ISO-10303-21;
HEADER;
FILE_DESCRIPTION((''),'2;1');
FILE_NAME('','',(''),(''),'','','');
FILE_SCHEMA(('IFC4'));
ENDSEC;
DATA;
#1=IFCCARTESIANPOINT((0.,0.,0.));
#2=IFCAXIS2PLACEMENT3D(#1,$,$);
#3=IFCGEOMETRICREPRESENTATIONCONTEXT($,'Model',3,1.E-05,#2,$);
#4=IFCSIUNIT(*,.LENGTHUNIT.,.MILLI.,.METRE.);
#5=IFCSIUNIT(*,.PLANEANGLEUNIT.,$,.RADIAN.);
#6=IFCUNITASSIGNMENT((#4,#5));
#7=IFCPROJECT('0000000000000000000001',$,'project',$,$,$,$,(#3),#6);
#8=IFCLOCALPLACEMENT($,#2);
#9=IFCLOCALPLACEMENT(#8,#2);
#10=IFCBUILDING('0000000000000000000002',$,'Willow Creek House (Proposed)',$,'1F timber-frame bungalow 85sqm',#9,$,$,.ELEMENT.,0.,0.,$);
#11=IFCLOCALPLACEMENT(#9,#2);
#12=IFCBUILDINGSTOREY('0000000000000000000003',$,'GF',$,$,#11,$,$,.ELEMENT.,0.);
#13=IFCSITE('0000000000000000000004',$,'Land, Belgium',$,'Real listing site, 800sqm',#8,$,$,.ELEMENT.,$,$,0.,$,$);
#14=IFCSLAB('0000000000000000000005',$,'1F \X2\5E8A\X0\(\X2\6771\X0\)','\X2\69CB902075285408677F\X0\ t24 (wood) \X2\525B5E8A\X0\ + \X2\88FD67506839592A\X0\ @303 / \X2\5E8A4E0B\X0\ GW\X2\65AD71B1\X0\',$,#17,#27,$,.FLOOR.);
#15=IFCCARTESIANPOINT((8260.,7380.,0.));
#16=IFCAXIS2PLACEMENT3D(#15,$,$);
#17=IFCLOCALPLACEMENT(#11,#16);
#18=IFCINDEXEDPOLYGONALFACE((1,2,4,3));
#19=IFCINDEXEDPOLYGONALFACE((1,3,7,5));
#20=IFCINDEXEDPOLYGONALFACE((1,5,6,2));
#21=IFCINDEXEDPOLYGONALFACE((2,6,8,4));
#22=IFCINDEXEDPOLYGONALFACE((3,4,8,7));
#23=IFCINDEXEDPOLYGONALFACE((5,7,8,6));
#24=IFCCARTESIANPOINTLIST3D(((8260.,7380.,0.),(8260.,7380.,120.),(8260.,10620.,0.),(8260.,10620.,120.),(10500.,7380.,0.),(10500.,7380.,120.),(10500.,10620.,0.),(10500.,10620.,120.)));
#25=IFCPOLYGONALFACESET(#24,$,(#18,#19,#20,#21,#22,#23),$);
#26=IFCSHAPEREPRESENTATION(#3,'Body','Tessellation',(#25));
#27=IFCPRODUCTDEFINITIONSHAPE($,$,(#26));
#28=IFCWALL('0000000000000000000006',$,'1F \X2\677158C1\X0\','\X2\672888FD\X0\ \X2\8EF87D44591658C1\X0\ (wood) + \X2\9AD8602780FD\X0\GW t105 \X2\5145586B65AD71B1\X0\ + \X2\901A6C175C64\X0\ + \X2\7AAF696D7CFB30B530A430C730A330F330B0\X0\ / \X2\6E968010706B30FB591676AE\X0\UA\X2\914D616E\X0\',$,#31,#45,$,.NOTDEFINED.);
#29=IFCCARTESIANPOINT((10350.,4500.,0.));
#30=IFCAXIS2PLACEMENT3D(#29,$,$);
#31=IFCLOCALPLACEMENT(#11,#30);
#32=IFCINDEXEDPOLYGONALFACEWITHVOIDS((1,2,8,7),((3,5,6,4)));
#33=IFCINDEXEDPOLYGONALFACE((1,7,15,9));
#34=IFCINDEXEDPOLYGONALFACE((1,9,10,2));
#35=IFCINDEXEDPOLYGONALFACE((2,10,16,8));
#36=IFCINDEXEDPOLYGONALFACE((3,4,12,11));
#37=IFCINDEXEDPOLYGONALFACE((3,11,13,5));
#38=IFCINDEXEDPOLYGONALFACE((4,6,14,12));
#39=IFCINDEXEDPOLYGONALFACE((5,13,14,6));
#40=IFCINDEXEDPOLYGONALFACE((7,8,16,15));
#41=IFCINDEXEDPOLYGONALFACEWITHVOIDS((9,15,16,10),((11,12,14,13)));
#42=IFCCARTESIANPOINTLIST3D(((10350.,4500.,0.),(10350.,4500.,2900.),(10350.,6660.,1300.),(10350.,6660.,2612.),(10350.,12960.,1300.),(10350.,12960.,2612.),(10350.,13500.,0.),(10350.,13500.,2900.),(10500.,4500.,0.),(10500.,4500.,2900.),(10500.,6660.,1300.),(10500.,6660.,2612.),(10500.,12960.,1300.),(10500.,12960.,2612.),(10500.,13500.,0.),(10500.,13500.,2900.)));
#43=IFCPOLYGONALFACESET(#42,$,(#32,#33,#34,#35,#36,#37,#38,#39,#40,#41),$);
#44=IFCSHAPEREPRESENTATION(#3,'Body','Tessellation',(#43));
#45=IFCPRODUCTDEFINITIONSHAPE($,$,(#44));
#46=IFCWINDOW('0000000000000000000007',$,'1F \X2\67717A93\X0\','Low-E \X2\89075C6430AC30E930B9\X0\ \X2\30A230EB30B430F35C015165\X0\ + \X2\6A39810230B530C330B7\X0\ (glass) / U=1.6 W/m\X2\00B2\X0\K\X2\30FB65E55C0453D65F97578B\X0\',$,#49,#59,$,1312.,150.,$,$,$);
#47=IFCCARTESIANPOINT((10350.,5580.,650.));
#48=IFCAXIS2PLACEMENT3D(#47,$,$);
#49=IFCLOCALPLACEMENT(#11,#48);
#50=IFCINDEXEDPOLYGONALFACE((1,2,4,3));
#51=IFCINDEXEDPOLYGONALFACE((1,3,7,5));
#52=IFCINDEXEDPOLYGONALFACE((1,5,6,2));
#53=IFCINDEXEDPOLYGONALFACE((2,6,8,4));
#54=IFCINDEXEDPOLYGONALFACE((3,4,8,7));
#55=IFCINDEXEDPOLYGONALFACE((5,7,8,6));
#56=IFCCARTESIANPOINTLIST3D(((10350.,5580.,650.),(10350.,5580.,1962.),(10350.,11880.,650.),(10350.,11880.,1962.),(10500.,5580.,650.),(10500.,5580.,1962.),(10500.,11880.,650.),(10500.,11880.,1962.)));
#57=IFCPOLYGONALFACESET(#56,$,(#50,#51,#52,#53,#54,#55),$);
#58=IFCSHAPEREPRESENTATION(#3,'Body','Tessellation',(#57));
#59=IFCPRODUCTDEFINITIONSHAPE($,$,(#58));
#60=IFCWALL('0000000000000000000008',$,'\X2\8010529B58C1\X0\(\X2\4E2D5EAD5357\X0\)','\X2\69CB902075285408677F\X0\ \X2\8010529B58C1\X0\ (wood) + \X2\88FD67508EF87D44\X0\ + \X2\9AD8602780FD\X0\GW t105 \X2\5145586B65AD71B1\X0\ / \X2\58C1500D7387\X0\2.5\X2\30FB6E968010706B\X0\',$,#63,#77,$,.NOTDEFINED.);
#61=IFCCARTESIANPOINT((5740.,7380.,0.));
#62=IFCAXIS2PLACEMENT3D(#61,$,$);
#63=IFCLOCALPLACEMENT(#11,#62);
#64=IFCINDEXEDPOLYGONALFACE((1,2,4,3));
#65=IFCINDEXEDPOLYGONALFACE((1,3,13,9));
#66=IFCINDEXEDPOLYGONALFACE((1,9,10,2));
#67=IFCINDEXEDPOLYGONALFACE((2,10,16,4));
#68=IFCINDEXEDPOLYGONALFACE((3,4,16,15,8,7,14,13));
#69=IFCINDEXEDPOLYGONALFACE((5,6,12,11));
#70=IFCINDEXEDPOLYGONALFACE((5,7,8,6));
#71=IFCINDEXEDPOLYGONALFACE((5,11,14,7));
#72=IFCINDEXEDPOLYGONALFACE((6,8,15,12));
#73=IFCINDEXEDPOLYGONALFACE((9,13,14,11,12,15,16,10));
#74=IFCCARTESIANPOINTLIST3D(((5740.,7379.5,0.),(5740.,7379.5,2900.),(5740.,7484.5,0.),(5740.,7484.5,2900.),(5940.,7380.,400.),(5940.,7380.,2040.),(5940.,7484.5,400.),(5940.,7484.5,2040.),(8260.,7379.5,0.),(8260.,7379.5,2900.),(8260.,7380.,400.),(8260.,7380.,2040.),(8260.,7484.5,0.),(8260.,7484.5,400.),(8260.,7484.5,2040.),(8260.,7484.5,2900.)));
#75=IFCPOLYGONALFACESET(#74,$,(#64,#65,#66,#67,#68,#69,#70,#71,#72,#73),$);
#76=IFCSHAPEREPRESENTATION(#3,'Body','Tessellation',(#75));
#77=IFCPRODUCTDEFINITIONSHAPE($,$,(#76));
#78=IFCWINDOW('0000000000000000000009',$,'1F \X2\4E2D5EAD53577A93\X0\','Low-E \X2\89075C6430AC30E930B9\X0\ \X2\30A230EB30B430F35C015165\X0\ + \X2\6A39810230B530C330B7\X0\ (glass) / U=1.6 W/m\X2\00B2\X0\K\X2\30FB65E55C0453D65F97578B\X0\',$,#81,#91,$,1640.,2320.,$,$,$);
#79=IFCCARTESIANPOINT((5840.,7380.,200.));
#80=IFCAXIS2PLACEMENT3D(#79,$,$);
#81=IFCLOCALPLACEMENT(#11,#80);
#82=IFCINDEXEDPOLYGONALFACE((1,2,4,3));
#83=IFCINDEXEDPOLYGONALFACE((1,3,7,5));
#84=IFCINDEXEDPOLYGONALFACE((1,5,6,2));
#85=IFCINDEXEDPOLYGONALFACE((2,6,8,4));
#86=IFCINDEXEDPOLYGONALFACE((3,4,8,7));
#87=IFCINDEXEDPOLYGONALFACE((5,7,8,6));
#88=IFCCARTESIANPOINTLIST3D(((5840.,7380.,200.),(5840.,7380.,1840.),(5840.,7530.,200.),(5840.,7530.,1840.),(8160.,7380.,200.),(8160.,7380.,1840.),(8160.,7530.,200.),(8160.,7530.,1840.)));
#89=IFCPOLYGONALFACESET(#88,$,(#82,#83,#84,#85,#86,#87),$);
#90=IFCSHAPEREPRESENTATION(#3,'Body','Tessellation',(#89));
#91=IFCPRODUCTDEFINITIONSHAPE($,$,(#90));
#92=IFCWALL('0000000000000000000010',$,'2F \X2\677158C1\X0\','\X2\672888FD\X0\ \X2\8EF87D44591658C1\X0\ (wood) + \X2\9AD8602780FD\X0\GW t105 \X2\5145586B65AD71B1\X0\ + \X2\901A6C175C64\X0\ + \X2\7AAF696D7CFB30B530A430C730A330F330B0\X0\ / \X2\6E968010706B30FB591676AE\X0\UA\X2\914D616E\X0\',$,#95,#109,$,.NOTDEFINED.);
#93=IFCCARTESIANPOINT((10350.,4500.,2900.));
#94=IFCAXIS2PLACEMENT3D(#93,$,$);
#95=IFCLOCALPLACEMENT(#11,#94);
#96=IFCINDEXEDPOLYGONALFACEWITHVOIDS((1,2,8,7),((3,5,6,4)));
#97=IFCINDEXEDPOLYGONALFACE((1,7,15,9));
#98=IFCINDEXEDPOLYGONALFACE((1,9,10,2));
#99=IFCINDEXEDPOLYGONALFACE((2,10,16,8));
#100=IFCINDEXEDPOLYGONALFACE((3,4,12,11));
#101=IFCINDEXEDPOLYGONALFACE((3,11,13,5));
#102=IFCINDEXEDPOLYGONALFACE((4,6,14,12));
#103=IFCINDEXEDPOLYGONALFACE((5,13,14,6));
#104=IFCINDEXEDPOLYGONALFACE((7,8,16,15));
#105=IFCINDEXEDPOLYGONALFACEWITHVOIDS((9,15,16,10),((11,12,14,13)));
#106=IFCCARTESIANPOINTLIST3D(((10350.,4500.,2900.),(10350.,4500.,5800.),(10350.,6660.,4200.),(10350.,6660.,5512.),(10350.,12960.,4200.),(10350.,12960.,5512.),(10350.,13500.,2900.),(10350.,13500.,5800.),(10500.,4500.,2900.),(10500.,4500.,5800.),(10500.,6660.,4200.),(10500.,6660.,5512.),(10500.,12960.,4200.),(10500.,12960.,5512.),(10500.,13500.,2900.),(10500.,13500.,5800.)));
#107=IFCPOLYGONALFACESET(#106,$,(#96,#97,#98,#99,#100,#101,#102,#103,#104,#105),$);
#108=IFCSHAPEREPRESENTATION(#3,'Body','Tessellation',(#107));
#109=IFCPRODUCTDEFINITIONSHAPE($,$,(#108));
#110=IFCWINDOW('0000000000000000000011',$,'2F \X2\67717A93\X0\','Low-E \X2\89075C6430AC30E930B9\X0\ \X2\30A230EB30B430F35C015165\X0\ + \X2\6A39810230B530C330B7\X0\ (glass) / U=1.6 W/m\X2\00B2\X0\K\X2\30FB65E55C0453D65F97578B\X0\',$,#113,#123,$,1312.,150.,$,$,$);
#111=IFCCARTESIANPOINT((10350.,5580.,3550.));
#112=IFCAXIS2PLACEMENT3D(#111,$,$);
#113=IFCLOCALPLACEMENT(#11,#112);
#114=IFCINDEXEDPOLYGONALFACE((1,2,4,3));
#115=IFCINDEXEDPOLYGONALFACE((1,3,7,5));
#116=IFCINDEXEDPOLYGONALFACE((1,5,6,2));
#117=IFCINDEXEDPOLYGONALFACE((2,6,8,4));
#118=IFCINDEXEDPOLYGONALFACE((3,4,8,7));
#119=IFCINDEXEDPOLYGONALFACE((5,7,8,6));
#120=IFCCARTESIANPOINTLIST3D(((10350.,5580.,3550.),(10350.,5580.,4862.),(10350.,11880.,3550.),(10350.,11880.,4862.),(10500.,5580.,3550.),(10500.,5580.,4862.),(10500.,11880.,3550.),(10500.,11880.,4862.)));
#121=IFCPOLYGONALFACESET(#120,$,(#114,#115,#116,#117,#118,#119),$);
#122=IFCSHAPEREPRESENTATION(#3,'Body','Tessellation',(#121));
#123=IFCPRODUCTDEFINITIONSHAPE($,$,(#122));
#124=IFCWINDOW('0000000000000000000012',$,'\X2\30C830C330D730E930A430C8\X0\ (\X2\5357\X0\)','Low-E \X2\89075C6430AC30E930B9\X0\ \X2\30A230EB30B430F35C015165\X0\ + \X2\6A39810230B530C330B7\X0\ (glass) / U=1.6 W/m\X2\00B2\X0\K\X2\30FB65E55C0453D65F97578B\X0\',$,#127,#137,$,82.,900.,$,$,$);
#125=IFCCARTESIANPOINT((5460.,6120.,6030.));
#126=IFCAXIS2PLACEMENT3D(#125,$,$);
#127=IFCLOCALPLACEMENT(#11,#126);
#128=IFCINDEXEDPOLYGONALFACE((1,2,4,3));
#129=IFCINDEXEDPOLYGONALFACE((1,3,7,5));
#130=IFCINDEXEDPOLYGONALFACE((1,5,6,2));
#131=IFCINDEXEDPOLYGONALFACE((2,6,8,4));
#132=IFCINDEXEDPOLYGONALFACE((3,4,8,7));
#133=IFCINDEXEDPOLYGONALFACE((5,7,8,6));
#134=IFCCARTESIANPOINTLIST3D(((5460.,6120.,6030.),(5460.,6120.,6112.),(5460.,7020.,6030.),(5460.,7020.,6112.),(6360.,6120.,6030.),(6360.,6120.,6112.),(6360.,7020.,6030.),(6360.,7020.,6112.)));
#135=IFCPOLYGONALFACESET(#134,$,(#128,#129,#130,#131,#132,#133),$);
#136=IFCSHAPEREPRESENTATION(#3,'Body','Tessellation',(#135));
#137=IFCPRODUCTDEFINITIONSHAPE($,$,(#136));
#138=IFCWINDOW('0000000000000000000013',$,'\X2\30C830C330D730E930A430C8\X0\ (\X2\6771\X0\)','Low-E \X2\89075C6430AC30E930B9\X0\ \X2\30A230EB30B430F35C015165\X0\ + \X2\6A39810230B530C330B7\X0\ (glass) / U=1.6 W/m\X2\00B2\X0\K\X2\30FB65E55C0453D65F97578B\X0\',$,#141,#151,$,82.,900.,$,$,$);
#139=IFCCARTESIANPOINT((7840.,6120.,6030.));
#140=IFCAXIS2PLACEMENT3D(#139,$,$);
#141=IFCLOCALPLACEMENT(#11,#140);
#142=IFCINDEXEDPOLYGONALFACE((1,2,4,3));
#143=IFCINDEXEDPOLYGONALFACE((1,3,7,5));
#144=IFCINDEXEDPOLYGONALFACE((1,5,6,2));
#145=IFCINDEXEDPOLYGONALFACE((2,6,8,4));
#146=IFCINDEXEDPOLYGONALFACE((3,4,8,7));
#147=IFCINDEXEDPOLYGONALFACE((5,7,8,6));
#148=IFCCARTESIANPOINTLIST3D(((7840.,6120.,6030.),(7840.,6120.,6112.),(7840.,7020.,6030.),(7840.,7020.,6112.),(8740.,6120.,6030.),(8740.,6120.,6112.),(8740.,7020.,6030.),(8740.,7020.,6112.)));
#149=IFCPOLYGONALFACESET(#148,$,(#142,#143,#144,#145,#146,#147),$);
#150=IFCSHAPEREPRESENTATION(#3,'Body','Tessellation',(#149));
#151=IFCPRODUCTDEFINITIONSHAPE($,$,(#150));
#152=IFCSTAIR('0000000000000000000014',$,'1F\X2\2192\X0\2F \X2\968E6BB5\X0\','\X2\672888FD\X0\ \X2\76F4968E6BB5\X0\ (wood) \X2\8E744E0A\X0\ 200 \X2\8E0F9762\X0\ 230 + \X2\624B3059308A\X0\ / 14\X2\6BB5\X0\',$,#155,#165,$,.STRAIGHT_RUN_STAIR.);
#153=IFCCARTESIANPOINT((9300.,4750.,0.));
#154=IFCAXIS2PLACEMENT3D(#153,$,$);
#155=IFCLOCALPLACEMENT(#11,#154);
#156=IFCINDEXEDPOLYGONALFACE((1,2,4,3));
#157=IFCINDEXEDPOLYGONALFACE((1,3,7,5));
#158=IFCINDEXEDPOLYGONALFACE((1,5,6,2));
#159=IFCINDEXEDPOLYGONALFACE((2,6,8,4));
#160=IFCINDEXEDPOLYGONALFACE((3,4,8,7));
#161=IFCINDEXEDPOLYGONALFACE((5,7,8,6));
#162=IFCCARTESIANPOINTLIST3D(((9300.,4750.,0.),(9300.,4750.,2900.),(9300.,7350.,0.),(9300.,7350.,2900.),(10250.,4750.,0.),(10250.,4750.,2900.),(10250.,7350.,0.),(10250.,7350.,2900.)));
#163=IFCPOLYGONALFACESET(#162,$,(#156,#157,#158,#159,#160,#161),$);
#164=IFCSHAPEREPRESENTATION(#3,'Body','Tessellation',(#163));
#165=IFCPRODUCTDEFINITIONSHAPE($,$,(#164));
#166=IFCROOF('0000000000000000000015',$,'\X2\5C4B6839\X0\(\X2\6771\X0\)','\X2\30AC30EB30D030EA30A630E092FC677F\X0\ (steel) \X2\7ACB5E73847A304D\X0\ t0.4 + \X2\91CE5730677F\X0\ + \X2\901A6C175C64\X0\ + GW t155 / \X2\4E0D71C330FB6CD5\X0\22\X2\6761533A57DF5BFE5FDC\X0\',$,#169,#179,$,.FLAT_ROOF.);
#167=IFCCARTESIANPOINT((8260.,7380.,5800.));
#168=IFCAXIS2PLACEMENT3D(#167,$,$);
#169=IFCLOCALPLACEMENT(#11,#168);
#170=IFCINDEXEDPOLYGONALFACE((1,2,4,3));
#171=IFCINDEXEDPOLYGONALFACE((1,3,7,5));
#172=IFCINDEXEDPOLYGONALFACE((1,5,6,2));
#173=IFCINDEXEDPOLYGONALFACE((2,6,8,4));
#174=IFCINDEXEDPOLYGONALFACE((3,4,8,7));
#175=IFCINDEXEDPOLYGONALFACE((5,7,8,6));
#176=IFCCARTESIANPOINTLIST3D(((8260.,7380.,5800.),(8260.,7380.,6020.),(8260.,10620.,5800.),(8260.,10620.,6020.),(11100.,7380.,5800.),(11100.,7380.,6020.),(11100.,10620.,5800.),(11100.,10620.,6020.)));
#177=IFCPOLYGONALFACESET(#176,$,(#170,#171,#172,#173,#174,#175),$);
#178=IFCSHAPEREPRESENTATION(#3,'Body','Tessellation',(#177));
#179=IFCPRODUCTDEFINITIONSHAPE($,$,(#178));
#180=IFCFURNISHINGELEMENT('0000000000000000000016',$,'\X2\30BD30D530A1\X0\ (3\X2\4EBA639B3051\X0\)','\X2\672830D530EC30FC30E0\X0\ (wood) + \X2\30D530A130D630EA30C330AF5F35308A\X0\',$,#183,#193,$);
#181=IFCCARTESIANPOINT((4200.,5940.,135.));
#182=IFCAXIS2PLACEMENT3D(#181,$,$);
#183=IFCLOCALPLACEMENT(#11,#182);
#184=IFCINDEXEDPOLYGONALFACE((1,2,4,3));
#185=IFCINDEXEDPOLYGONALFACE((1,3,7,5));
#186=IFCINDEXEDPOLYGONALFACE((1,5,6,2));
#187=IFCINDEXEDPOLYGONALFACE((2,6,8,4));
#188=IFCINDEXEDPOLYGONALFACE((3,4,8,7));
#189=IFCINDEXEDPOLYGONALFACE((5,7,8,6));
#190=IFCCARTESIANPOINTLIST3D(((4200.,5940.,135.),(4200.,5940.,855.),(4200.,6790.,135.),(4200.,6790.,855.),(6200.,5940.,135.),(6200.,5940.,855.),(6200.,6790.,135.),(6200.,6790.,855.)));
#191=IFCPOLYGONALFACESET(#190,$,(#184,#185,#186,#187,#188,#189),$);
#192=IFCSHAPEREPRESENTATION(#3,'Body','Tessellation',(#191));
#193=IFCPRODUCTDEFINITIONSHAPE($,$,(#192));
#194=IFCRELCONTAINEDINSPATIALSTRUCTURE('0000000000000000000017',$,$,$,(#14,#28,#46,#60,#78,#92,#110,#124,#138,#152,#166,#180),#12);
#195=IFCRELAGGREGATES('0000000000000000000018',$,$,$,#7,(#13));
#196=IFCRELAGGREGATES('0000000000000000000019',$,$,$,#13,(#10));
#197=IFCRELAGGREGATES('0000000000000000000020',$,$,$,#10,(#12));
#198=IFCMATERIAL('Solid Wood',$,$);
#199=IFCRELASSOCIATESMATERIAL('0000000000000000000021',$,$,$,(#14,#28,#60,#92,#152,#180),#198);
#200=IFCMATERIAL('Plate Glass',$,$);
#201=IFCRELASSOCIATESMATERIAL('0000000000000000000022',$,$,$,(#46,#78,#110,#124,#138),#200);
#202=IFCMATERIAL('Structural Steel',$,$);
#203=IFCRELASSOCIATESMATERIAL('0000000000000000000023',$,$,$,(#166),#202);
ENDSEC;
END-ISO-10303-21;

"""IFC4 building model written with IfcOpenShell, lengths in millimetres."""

from ifc_helpers import new_model, si_unit, frame, frame_2d, origin, place, context, project, spatial, rectangle, extrude, material, element, fill, save


model = new_model("IFC4")

# Units and contexts
model_context = context("Model", 3, precision=1e-05, world=origin())
ifc_project = project(units=[si_unit("LENGTHUNIT", "METRE", prefix="MILLI"), si_unit("PLANEANGLEUNIT", "RADIAN")], contexts=[model_context])

# Site, building, storey
site_placement = place(None, origin())
site = spatial("IfcSite", under=ifc_project, at=site_placement, Name="Land, Belgium", ObjectType="Real listing site, 800sqm", CompositionType="ELEMENT", RefElevation=0.0)
building_placement = place(site_placement, origin())
building = spatial("IfcBuilding", under=site, at=building_placement, Name="Willow Creek House (Proposed)", ObjectType="1F timber-frame bungalow 85sqm", CompositionType="ELEMENT", ElevationOfRefHeight=0.0, ElevationOfTerrain=0.0)
storey_placement = place(building_placement, origin())
storey = spatial("IfcBuildingStorey", under=building, at=storey_placement, Name="GF", CompositionType="ELEMENT", Elevation=0.0)

# Slab
ifc_material_1 = material(Name="Solid Wood")
slab_placement = place(storey_placement, frame((8260.0, 7380.0, 0.0)))
element("IfcSlab", 1, at=slab_placement, inside=storey, material=ifc_material_1, Name="1F 床(東)", Description="構造用合板 t24 (wood) 剛床 + 製材根太 @303 / 床下 GW断熱", PredefinedType="FLOOR", context=model_context, shape_type="SweptSolid", body=[
    extrude(rectangle(XDim=2240.0, YDim=3240.0, at=frame_2d((1120.0, 1620.0))), frame((8260.0, 7380.0, 0.0)), (0.0, 0.0, 1.0), 120.0),
])

# Walls, openings, windows
wall_1_placement = place(storey_placement, frame((10350.0, 4500.0, 0.0)))
wall_1 = element("IfcWall", 2, at=wall_1_placement, inside=storey, material=ifc_material_1, Name="1F 東壁", Description="木製 軸組外壁 (wood) + 高性能GW t105 充填断熱 + 通気層 + 窯業系サイディング / 準耐火・外皮UA配慮", PredefinedType="NOTDEFINED", context=model_context, shape_type="SweptSolid", body=[
    extrude(rectangle(XDim=150.0, YDim=9000.0, at=frame_2d((75.0, 4500.0))), frame((10350.0, 4500.0, 0.0)), (0.0, 0.0, 1.0), 2900.0),
])
opening_1_placement = place(storey_placement, frame((10350.0, 5580.0, 650.0)))
opening_1 = element("IfcOpeningElement", 3, at=opening_1_placement, cuts=wall_1, PredefinedType="NOTDEFINED", context=model_context, shape_type="SweptSolid", body=[
    extrude(rectangle(XDim=150.0, YDim=6300.0, at=frame_2d((75.0, 3150.0))), frame((10350.0, 5580.0, 650.0)), (0.0, 0.0, 1.0), 1312.0),
])
ifc_material_2 = material(Name="Plate Glass")
window_1_placement = place(storey_placement, frame((10350.0, 5580.0, 650.0)))
window_1 = element("IfcWindow", 4, at=window_1_placement, inside=storey, material=ifc_material_2, Name="1F 東窓", Description="Low-E 複層ガラス アルゴン封入 + 樹脂サッシ (glass) / U=1.6 W/m²K・日射取得型", OverallHeight=1312.0, OverallWidth=150.0, context=model_context, shape_type="SweptSolid", body=[
    extrude(rectangle(XDim=150.0, YDim=6300.0, at=frame_2d((75.0, 3150.0))), frame((10350.0, 5580.0, 650.0)), (0.0, 0.0, 1.0), 1312.0),
])
fill(opening_1, window_1)
wall_2_placement = place(storey_placement, frame((5740.0, 7380.0, 0.0)))
wall_2 = element("IfcWall", 5, at=wall_2_placement, inside=storey, material=ifc_material_1, Name="耐力壁(中庭南)", Description="構造用合板 耐力壁 (wood) + 製材軸組 + 高性能GW t105 充填断熱 / 壁倍率2.5・準耐火", PredefinedType="NOTDEFINED", context=model_context, shape_type="SweptSolid", body=[
    extrude(rectangle(XDim=2520.0, YDim=105.0, at=frame_2d((1260.0, 52.0))), frame((5740.0, 7380.0, 0.0)), (0.0, 0.0, 1.0), 2900.0),
])
opening_2_placement = place(storey_placement, frame((5840.0, 7380.0, 200.0)))
opening_2 = element("IfcOpeningElement", 6, at=opening_2_placement, cuts=wall_2, PredefinedType="NOTDEFINED", context=model_context, shape_type="SweptSolid", body=[
    extrude(rectangle(XDim=2320.0, YDim=150.0, at=frame_2d((1160.0, 75.0))), frame((5840.0, 7380.0, 200.0)), (0.0, 0.0, 1.0), 1640.0),
])
window_2_placement = place(storey_placement, frame((5840.0, 7380.0, 200.0)))
window_2 = element("IfcWindow", 7, at=window_2_placement, inside=storey, material=ifc_material_2, Name="1F 中庭南窓", Description="Low-E 複層ガラス アルゴン封入 + 樹脂サッシ (glass) / U=1.6 W/m²K・日射取得型", OverallHeight=1640.0, OverallWidth=2320.0, context=model_context, shape_type="SweptSolid", body=[
    extrude(rectangle(XDim=2320.0, YDim=150.0, at=frame_2d((1160.0, 75.0))), frame((5840.0, 7380.0, 200.0)), (0.0, 0.0, 1.0), 1640.0),
])
fill(opening_2, window_2)

# Wall, opening, window
wall_3_placement = place(storey_placement, frame((10350.0, 4500.0, 2900.0)))
wall_3 = element("IfcWall", 8, at=wall_3_placement, inside=storey, material=ifc_material_1, Name="2F 東壁", Description="木製 軸組外壁 (wood) + 高性能GW t105 充填断熱 + 通気層 + 窯業系サイディング / 準耐火・外皮UA配慮", PredefinedType="NOTDEFINED", context=model_context, shape_type="SweptSolid", body=[
    extrude(rectangle(XDim=150.0, YDim=9000.0, at=frame_2d((75.0, 4500.0))), frame((10350.0, 4500.0, 2900.0)), (0.0, 0.0, 1.0), 2900.0),
])
opening_3_placement = place(storey_placement, frame((10350.0, 5580.0, 3550.0)))
opening_3 = element("IfcOpeningElement", 9, at=opening_3_placement, cuts=wall_3, PredefinedType="NOTDEFINED", context=model_context, shape_type="SweptSolid", body=[
    extrude(rectangle(XDim=150.0, YDim=6300.0, at=frame_2d((75.0, 3150.0))), frame((10350.0, 5580.0, 3550.0)), (0.0, 0.0, 1.0), 1312.0),
])
window_3_placement = place(storey_placement, frame((10350.0, 5580.0, 3550.0)))
window_3 = element("IfcWindow", 10, at=window_3_placement, inside=storey, material=ifc_material_2, Name="2F 東窓", Description="Low-E 複層ガラス アルゴン封入 + 樹脂サッシ (glass) / U=1.6 W/m²K・日射取得型", OverallHeight=1312.0, OverallWidth=150.0, context=model_context, shape_type="SweptSolid", body=[
    extrude(rectangle(XDim=150.0, YDim=6300.0, at=frame_2d((75.0, 3150.0))), frame((10350.0, 5580.0, 3550.0)), (0.0, 0.0, 1.0), 1312.0),
])
fill(opening_3, window_3)

# Windows
window_4_placement = place(storey_placement, frame((5460.0, 6120.0, 6030.0)))
element("IfcWindow", 11, at=window_4_placement, inside=storey, material=ifc_material_2, Name="トップライト (南)", Description="Low-E 複層ガラス アルゴン封入 + 樹脂サッシ (glass) / U=1.6 W/m²K・日射取得型", OverallHeight=82.0, OverallWidth=900.0, context=model_context, shape_type="SweptSolid", body=[
    extrude(rectangle(XDim=900.0, YDim=900.0, at=frame_2d((450.0, 450.0))), frame((5460.0, 6120.0, 6030.0)), (0.0, 0.0, 1.0), 82.0),
])
window_5_placement = place(storey_placement, frame((7840.0, 6120.0, 6030.0)))
element("IfcWindow", 12, at=window_5_placement, inside=storey, material=ifc_material_2, Name="トップライト (東)", Description="Low-E 複層ガラス アルゴン封入 + 樹脂サッシ (glass) / U=1.6 W/m²K・日射取得型", OverallHeight=82.0, OverallWidth=900.0, context=model_context, shape_type="SweptSolid", body=[
    extrude(rectangle(XDim=900.0, YDim=900.0, at=frame_2d((450.0, 450.0))), frame((7840.0, 6120.0, 6030.0)), (0.0, 0.0, 1.0), 82.0),
])

# Stair
stair_placement = place(storey_placement, frame((9300.0, 4750.0, 0.0)))
element("IfcStair", 13, at=stair_placement, inside=storey, material=ifc_material_1, Name="1F→2F 階段", Description="木製 直階段 (wood) 蹴上 200 踏面 230 + 手すり / 14段", PredefinedType="STRAIGHT_RUN_STAIR", context=model_context, shape_type="SweptSolid", body=[
    extrude(rectangle(XDim=950.0, YDim=2600.0, at=frame_2d((475.0, 1300.0))), frame((9300.0, 4750.0, 0.0)), (0.0, 0.0, 1.0), 2900.0),
])

# Roof
ifc_material_3 = material(Name="Structural Steel")
roof_placement = place(storey_placement, frame((8260.0, 7380.0, 5800.0)))
element("IfcRoof", 14, at=roof_placement, inside=storey, material=ifc_material_3, Name="屋根(東)", Description="ガルバリウム鋼板 (steel) 立平葺き t0.4 + 野地板 + 通気層 + GW t155 / 不燃・法22条区域対応", PredefinedType="FLAT_ROOF", context=model_context, shape_type="SweptSolid", body=[
    extrude(rectangle(XDim=2840.0, YDim=3240.0, at=frame_2d((1420.0, 1620.0))), frame((8260.0, 7380.0, 5800.0)), (0.0, 0.0, 1.0), 220.0),
])

# Furnishing element
furnishing_1_placement = place(storey_placement, frame((4200.0, 5940.0, 135.0)))
element("IfcFurnishingElement", 15, at=furnishing_1_placement, inside=storey, material=ifc_material_1, Name="ソファ (3人掛け)", Description="木フレーム (wood) + ファブリック張り", context=model_context, shape_type="SweptSolid", body=[
    extrude(rectangle(XDim=2000.0, YDim=850.0, at=frame_2d((1000.0, 425.0))), frame((4200.0, 5940.0, 135.0)), (0.0, 0.0, 1.0), 720.0),
])

save(model, "model.ifc")
